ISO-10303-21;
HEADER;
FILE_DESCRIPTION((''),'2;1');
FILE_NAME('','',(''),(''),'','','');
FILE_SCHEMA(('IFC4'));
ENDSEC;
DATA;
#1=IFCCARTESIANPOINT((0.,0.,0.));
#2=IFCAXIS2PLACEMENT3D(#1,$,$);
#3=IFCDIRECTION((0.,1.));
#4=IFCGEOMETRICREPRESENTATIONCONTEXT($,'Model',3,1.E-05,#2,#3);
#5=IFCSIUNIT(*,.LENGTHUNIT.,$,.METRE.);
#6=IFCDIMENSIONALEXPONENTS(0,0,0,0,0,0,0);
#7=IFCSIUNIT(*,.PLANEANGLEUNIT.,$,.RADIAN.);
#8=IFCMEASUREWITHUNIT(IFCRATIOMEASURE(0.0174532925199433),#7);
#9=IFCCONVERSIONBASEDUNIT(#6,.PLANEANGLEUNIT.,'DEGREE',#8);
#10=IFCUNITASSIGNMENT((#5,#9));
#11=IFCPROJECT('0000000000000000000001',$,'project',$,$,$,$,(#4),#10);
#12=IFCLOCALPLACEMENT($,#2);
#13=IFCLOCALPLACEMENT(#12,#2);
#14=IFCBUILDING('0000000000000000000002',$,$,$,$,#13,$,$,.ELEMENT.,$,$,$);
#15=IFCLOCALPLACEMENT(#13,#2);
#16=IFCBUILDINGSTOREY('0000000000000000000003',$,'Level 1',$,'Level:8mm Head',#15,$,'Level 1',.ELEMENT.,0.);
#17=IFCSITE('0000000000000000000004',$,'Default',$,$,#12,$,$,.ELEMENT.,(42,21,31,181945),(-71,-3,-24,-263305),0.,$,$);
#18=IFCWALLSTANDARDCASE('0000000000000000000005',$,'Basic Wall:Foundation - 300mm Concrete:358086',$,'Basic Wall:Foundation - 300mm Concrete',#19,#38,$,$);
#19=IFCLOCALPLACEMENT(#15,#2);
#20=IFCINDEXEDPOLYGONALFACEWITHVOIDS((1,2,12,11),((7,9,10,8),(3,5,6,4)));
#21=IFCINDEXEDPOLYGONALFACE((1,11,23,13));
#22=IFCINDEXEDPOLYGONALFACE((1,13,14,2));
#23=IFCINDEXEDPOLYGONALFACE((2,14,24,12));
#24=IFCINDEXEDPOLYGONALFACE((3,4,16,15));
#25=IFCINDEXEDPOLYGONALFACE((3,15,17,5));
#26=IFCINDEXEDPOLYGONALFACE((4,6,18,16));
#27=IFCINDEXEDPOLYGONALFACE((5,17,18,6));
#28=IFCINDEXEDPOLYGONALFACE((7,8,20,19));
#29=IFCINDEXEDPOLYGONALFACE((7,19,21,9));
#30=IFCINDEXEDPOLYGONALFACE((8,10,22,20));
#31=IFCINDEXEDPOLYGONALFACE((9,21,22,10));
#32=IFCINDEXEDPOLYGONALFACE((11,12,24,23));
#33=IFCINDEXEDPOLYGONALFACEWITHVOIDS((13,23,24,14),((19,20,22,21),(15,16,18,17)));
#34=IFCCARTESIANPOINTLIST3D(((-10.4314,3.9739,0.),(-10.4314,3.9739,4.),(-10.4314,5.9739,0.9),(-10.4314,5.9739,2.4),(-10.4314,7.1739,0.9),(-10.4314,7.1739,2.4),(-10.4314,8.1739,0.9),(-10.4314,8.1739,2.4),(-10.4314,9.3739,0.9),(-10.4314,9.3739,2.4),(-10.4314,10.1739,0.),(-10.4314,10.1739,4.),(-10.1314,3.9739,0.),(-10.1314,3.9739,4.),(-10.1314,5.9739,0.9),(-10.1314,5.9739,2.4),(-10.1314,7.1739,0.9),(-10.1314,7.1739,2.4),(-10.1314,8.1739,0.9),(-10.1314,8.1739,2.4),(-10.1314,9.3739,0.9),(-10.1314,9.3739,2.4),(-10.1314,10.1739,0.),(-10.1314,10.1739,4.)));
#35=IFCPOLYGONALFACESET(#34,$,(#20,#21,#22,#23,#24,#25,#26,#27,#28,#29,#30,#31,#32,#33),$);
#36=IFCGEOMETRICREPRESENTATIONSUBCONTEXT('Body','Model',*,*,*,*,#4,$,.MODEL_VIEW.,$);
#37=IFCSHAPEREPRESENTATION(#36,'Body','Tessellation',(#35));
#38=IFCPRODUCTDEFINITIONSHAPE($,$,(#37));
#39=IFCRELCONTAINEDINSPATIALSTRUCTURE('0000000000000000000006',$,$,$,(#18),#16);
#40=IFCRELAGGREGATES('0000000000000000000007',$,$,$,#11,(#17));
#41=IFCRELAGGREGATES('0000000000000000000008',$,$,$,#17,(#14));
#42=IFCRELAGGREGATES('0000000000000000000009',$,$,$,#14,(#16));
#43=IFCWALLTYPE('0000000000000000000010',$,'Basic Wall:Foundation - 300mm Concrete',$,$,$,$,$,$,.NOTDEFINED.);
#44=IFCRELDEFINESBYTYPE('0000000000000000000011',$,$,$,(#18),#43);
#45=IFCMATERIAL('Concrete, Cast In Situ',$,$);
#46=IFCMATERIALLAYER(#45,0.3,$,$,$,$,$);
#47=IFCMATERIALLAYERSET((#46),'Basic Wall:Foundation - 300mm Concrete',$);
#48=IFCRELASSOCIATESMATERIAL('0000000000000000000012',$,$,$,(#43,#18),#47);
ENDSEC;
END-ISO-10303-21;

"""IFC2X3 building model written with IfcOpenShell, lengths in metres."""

from ifc_helpers import new_model, entity, si_unit, converted_unit, direction, frame, frame_2d, origin, place, context, subcontext, project, spatial, rectangle, extrude, material, layer, layer_set, layer_usage, type_object, element, save


model = new_model("IFC2X3")

# Units and contexts
model_context = context("Model", 3, precision=1e-05, world=origin(), true_north=direction((0.0, 1.0)))
body_context = subcontext(model_context, "Body", "Model", "MODEL_VIEW")
ifc_project = project(units=[si_unit("LENGTHUNIT", "METRE"), converted_unit("PLANEANGLEUNIT", "DEGREE", entity("IfcRatioMeasure", 0.0174532925199433), si_unit("PLANEANGLEUNIT", "RADIAN"), dimensions=[0, 0, 0, 0, 0, 0, 0])], contexts=[model_context])

# Site, building, storey
site_placement = place(None, origin())
site = spatial("IfcSite", under=ifc_project, at=site_placement, Name="Default", CompositionType="ELEMENT", RefLatitude=(42, 21, 31, 181945), RefLongitude=(-71, -3, -24, -263305), RefElevation=0.0)
building_placement = place(site_placement, origin())
building = spatial("IfcBuilding", under=site, at=building_placement, CompositionType="ELEMENT")
storey_placement = place(building_placement, origin())
storey = spatial("IfcBuildingStorey", under=building, at=storey_placement, Name="Level 1", ObjectType="Level:8mm Head", LongName="Level 1", CompositionType="ELEMENT", Elevation=0.0)

# Shared definitions
ifc_material_1 = material(Name="Concrete, Cast In Situ")
ifc_layer = layer(ifc_material_1, 0.3)
ifc_layer_set = layer_set([ifc_layer], Name="Basic Wall:Foundation - 300mm Concrete")
wall_type = type_object("IfcWallType", Name="Basic Wall:Foundation - 300mm Concrete", PredefinedType="NOTDEFINED", material=ifc_layer_set)

# Wall, openings
ifc_layer_usage_1 = layer_usage(ifc_layer_set, "AXIS2", "NEGATIVE", 0.15)
wall_1_placement = place(storey_placement, frame((-10.2814, 3.9739, 0.0), z_axis=(0.0, 0.0, 1.0), x_axis=(0.0, 1.0, 0.0)))
wall_1 = element("IfcWallStandardCase", 1, at=wall_1_placement, inside=storey, type_object=wall_type, material=ifc_layer_usage_1, Name="Basic Wall:Foundation - 300mm Concrete:358086", ObjectType="Basic Wall:Foundation - 300mm Concrete", context=body_context, shape_type="SweptSolid", body=[
    extrude(rectangle(XDim=6.2, YDim=0.3, at=frame_2d((3.1, 0.0), x_axis=(-1.0, 0.0))), origin(), (0.0, 0.0, 1.0), 4.0),
])
opening_1_placement = place(wall_1_placement, frame((5.4, 0.15, 0.9)))
element("IfcOpeningElement", 2, at=opening_1_placement, cuts=wall_1, ObjectType="Opening", context=body_context, shape_type="SweptSolid", body=[
    extrude(rectangle(XDim=1.5, YDim=1.2, at=frame_2d((0.75, 0.6), x_axis=(-1.0, 0.0))), frame((0.0, 0.0, 0.0), z_axis=(0.0, -1.0, 0.0), x_axis=(0.0, 0.0, 1.0)), (0.0, 0.0, 1.0), 0.3),
])
opening_2_placement = place(wall_1_placement, frame((3.2, 0.15, 0.9)))
element("IfcOpeningElement", 3, at=opening_2_placement, cuts=wall_1, ObjectType="Opening", context=body_context, shape_type="SweptSolid", body=[
    extrude(rectangle(XDim=1.5, YDim=1.2, at=frame_2d((0.75, 0.6), x_axis=(-1.0, 0.0))), frame((0.0, 0.0, 0.0), z_axis=(0.0, -1.0, 0.0), x_axis=(0.0, 0.0, 1.0)), (0.0, 0.0, 1.0), 0.3),
])

save(model, "model.ifc")
